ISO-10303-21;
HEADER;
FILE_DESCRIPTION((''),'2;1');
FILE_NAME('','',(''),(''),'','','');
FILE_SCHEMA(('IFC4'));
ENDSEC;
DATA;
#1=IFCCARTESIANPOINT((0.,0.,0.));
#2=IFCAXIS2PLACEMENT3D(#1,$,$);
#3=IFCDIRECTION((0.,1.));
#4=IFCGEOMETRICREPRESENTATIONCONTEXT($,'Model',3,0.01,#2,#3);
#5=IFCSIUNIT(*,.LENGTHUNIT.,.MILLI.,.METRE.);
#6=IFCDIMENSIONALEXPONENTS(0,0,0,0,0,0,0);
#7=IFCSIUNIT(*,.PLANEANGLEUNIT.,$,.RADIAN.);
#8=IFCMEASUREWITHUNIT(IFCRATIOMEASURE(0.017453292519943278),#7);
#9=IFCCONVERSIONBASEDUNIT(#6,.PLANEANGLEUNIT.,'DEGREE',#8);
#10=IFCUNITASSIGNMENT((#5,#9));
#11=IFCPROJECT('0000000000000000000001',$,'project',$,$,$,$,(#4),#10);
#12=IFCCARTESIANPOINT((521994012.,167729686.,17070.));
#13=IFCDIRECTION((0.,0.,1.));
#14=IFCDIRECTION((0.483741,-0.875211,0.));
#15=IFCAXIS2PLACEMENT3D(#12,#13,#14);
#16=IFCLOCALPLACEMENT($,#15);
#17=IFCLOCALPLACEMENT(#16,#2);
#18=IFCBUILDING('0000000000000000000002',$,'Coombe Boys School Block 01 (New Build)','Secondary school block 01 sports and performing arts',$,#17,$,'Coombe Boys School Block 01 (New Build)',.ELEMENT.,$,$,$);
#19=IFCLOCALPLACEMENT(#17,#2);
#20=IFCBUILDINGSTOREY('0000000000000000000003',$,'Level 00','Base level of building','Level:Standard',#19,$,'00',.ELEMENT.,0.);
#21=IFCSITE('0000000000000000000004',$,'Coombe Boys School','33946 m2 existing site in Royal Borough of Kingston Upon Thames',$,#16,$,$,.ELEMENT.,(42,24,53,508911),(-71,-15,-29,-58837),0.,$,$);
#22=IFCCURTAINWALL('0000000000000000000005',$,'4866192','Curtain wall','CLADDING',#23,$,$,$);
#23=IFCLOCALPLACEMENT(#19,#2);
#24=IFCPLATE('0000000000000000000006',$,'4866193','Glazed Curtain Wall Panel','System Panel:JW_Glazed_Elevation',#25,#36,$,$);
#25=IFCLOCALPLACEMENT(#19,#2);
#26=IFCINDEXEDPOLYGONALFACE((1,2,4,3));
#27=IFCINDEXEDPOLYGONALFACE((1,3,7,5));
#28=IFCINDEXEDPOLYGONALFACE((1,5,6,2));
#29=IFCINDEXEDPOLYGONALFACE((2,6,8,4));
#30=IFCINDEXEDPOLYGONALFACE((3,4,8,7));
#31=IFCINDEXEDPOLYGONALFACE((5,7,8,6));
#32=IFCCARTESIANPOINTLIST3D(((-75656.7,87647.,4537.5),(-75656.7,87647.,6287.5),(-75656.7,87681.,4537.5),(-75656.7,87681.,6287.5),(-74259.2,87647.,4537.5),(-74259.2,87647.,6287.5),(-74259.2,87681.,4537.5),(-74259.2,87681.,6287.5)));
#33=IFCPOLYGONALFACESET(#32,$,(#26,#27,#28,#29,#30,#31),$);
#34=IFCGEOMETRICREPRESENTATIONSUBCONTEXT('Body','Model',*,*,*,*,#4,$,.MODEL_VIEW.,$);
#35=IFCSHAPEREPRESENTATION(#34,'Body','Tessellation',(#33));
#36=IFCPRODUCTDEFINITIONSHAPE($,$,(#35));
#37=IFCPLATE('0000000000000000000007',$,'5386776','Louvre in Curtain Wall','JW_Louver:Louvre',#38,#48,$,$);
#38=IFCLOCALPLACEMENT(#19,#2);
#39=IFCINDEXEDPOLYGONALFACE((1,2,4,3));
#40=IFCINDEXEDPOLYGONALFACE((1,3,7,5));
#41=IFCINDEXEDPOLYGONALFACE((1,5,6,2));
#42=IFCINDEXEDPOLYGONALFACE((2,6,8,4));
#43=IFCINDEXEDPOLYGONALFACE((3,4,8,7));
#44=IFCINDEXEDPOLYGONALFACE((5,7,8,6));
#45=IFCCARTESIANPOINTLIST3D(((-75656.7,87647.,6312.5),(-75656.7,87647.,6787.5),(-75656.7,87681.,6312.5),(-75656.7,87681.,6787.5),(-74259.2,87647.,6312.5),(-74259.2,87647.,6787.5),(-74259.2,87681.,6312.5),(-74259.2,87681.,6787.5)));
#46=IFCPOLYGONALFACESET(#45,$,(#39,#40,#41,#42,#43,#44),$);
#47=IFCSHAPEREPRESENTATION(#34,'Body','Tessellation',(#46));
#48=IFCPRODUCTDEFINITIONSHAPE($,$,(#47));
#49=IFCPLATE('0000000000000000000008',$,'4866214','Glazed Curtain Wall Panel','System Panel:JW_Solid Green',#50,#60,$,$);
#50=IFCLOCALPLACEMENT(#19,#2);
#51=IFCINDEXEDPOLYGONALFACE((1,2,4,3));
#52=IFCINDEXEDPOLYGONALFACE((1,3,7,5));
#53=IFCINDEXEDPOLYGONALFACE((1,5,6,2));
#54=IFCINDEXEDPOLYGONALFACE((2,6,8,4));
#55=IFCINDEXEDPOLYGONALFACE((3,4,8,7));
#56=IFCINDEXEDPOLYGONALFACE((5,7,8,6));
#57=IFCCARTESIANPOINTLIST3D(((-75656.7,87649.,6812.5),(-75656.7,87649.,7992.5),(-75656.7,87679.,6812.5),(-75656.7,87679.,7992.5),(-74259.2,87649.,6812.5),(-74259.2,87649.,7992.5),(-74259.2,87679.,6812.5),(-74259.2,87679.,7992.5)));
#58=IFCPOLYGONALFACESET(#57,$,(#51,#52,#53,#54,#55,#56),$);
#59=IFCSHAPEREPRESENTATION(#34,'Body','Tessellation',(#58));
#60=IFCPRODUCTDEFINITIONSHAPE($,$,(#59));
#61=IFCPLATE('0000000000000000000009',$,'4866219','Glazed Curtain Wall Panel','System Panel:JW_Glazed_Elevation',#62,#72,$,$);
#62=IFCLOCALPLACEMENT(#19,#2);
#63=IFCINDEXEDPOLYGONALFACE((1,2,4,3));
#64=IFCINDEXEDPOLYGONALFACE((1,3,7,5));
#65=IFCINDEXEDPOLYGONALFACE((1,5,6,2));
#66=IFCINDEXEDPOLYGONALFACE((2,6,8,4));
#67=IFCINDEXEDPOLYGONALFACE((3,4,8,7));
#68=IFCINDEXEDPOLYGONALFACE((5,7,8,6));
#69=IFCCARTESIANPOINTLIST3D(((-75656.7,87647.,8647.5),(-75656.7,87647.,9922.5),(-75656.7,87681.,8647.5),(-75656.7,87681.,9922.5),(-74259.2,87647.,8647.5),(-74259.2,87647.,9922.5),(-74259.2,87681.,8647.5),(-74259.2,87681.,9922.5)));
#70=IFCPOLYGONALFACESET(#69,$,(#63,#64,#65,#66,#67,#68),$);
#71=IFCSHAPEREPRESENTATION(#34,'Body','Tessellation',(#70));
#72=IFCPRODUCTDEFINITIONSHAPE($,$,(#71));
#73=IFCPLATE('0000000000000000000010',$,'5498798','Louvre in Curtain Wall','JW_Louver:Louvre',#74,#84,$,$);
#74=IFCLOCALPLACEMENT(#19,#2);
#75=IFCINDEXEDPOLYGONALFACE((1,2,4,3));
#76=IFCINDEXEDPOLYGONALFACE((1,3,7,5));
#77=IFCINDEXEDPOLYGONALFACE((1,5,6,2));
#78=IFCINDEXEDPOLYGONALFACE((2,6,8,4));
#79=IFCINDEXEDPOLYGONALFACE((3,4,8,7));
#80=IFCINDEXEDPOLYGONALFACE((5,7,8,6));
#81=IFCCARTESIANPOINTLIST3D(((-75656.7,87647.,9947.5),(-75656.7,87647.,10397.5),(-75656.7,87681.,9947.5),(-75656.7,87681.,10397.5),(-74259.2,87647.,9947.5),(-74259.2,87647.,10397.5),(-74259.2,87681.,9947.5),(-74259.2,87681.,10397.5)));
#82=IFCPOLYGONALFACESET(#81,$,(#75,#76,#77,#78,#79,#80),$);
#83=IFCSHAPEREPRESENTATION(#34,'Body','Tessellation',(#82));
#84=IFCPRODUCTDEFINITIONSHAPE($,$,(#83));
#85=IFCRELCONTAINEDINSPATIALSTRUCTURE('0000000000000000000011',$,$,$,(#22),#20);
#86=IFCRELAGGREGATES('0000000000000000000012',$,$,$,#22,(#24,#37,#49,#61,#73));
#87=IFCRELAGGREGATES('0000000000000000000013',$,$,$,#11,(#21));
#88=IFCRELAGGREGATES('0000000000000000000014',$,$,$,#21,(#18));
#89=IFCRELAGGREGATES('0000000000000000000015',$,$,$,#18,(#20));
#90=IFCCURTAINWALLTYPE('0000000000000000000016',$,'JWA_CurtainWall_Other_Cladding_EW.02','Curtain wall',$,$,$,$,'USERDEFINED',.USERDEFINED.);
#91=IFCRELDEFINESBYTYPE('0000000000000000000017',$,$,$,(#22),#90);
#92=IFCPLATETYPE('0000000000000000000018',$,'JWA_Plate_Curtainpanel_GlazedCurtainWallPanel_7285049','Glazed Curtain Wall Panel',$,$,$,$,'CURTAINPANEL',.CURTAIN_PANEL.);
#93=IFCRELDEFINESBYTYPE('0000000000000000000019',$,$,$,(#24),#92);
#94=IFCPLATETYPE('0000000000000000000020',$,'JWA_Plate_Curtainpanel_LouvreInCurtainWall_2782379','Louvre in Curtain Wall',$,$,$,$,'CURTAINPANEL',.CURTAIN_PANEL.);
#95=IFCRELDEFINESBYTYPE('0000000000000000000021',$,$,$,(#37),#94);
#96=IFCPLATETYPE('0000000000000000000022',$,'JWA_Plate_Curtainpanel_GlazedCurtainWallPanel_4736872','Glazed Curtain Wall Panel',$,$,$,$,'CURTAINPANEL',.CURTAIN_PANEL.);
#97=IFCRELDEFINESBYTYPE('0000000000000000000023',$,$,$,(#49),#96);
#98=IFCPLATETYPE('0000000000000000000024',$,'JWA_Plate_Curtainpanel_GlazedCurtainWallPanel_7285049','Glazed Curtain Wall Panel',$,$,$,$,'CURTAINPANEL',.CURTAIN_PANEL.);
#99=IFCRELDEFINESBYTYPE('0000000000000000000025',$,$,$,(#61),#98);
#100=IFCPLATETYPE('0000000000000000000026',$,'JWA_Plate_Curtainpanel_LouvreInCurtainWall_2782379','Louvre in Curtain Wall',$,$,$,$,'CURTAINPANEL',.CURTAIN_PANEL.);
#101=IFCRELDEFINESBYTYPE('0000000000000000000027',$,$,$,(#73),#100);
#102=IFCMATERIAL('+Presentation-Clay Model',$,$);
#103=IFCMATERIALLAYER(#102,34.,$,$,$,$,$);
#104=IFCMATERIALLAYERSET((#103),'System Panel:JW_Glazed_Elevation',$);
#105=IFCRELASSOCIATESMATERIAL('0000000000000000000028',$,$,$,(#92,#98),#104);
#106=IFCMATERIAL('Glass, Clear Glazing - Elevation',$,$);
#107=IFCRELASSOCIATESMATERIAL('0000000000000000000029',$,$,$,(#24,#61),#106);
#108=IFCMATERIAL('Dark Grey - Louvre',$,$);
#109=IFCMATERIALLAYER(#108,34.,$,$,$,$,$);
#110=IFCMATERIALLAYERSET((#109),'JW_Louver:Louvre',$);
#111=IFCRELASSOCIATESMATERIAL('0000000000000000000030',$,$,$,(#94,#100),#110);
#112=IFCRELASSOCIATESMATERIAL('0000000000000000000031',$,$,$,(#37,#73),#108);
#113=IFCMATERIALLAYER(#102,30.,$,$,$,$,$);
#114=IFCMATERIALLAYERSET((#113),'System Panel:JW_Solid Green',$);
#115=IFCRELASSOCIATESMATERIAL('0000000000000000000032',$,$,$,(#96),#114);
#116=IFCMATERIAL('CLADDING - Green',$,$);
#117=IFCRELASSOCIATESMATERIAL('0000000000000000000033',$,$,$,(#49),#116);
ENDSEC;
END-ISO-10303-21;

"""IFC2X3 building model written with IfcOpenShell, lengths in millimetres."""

from ifc_helpers import new_model, entity, si_unit, converted_unit, direction, frame, origin, origin_2d_with_axis, place, context, subcontext, project, spatial, rectangle, extrude, source, transform, mapped, material, layer, layer_set, type_object, type_shapes, element, aggregate, save


model = new_model("IFC2X3")

# Units and contexts
model_context = context("Model", 3, precision=0.01, world=origin(), true_north=direction((0.0, 1.0)))
body_context = subcontext(model_context, "Body", "Model", "MODEL_VIEW")
ifc_project = project(units=[si_unit("LENGTHUNIT", "METRE", prefix="MILLI"), converted_unit("PLANEANGLEUNIT", "DEGREE", entity("IfcRatioMeasure", 0.017453292519943278), si_unit("PLANEANGLEUNIT", "RADIAN"), dimensions=[0, 0, 0, 0, 0, 0, 0])], contexts=[model_context])

# Site, building, storey
site_placement = place(None, frame((521994012.0, 167729686.0, 17070.0), z_axis=(0.0, 0.0, 1.0), x_axis=(0.483741, -0.875211, 0.0)))
site = spatial("IfcSite", under=ifc_project, at=site_placement, Name="Coombe Boys School", Description="33946 m2 existing site in Royal Borough of Kingston Upon Thames", CompositionType="ELEMENT", RefLatitude=(42, 24, 53, 508911), RefLongitude=(-71, -15, -29, -58837), RefElevation=0.0)
building_placement = place(site_placement, origin())
building = spatial("IfcBuilding", under=site, at=building_placement, Name="Coombe Boys School Block 01 (New Build)", Description="Secondary school block 01 sports and performing arts", LongName="Coombe Boys School Block 01 (New Build)", CompositionType="ELEMENT")
storey_placement = place(building_placement, origin())
storey = spatial("IfcBuildingStorey", under=building, at=storey_placement, Name="Level 00", Description="Base level of building", ObjectType="Level:Standard", LongName="00", CompositionType="ELEMENT", Elevation=0.0)

# Curtain wall
curtain_wall_type = type_object("IfcCurtainWallType", Name="JWA_CurtainWall_Other_Cladding_EW.02", Description="Curtain wall", ElementType="USERDEFINED", PredefinedType="USERDEFINED")
curtain_wall_1_placement = place(storey_placement, origin())
curtain_wall_1 = element("IfcCurtainWall", 1, at=curtain_wall_1_placement, inside=storey, type_object=curtain_wall_type, Name="4866192", Description="Curtain wall", ObjectType="CLADDING")

# Plates
ifc_material_1 = material(Name="Glass, Clear Glazing - Elevation")
ifc_material_2 = material(Name="+Presentation-Clay Model")
ifc_layer_1 = layer(ifc_material_2, 34.0)
ifc_layer_set_1 = layer_set([ifc_layer_1], Name="System Panel:JW_Glazed_Elevation")
plate_type_1 = type_object("IfcPlateType", Name="JWA_Plate_Curtainpanel_GlazedCurtainWallPanel_7285049", Description="Glazed Curtain Wall Panel", ElementType="CURTAINPANEL", PredefinedType="CURTAIN_PANEL", material=ifc_layer_set_1)
shared_shape_1 = source(origin(), body_context, "Body", "SweptSolid", [
    extrude(rectangle(XDim=34.0, YDim=1397.5, at=origin_2d_with_axis()), frame((0.0, 0.0, 0.0), z_axis=(0.0, 0.0, 1.0), x_axis=(0.0, 1.0, 0.0)), (0.0, 0.0, 1.0), 1750.0),
])
type_shapes(plate_type_1, [shared_shape_1])
plate_1_placement = place(curtain_wall_1_placement, frame((-74958.0, 87664.0, 4537.5)))
plate_1 = element("IfcPlate", 2, at=plate_1_placement, type_object=plate_type_1, material=ifc_material_1, Name="4866193", Description="Glazed Curtain Wall Panel", ObjectType="System Panel:JW_Glazed_Elevation", context=body_context, shape_type="MappedRepresentation", body=[
    mapped(shared_shape_1, transform((0.0, 0.0, 0.0), scale=1.0)),
])
ifc_material_3 = material(Name="Dark Grey - Louvre")
ifc_layer_2 = layer(ifc_material_3, 34.0)
ifc_layer_set_2 = layer_set([ifc_layer_2], Name="JW_Louver:Louvre")
plate_type_2 = type_object("IfcPlateType", Name="JWA_Plate_Curtainpanel_LouvreInCurtainWall_2782379", Description="Louvre in Curtain Wall", ElementType="CURTAINPANEL", PredefinedType="CURTAIN_PANEL", material=ifc_layer_set_2)
shared_shape_2 = source(origin(), body_context, "Body", "SweptSolid", [
    extrude(rectangle(XDim=34.0, YDim=1397.5, at=origin_2d_with_axis()), frame((0.0, 0.0, 0.0), z_axis=(0.0, 0.0, 1.0), x_axis=(0.0, 1.0, 0.0)), (0.0, 0.0, 1.0), 475.0),
])
type_shapes(plate_type_2, [shared_shape_2])
plate_2_placement = place(curtain_wall_1_placement, frame((-74958.0, 87664.0, 6312.5)))
plate_2 = element("IfcPlate", 3, at=plate_2_placement, type_object=plate_type_2, material=ifc_material_3, Name="5386776", Description="Louvre in Curtain Wall", ObjectType="JW_Louver:Louvre", context=body_context, shape_type="MappedRepresentation", body=[
    mapped(shared_shape_2, transform((0.0, 0.0, 0.0), scale=1.0)),
])
ifc_material_4 = material(Name="CLADDING - Green")
ifc_layer_3 = layer(ifc_material_2, 30.0)
ifc_layer_set_3 = layer_set([ifc_layer_3], Name="System Panel:JW_Solid Green")
plate_type_3 = type_object("IfcPlateType", Name="JWA_Plate_Curtainpanel_GlazedCurtainWallPanel_4736872", Description="Glazed Curtain Wall Panel", ElementType="CURTAINPANEL", PredefinedType="CURTAIN_PANEL", material=ifc_layer_set_3)
shared_shape_3 = source(origin(), body_context, "Body", "SweptSolid", [
    extrude(rectangle(XDim=30.0, YDim=1397.5, at=origin_2d_with_axis()), frame((0.0, 0.0, 0.0), z_axis=(0.0, 0.0, 1.0), x_axis=(0.0, 1.0, 0.0)), (0.0, 0.0, 1.0), 1180.0),
])
type_shapes(plate_type_3, [shared_shape_3])
plate_3_placement = place(curtain_wall_1_placement, frame((-74958.0, 87664.0, 6812.5)))
plate_3 = element("IfcPlate", 4, at=plate_3_placement, type_object=plate_type_3, material=ifc_material_4, Name="4866214", Description="Glazed Curtain Wall Panel", ObjectType="System Panel:JW_Solid Green", context=body_context, shape_type="MappedRepresentation", body=[
    mapped(shared_shape_3, transform((0.0, 0.0, 0.0), scale=1.0)),
])
plate_type_4 = type_object("IfcPlateType", Name="JWA_Plate_Curtainpanel_GlazedCurtainWallPanel_7285049", Description="Glazed Curtain Wall Panel", ElementType="CURTAINPANEL", PredefinedType="CURTAIN_PANEL", material=ifc_layer_set_1)
shared_shape_4 = source(origin(), body_context, "Body", "SweptSolid", [
    extrude(rectangle(XDim=34.0, YDim=1397.5, at=origin_2d_with_axis()), frame((0.0, 0.0, 0.0), z_axis=(0.0, 0.0, 1.0), x_axis=(0.0, 1.0, 0.0)), (0.0, 0.0, 1.0), 1275.0),
])
type_shapes(plate_type_4, [shared_shape_4])
plate_4_placement = place(curtain_wall_1_placement, frame((-74958.0, 87664.0, 8647.5)))
plate_4 = element("IfcPlate", 5, at=plate_4_placement, type_object=plate_type_4, material=ifc_material_1, Name="4866219", Description="Glazed Curtain Wall Panel", ObjectType="System Panel:JW_Glazed_Elevation", context=body_context, shape_type="MappedRepresentation", body=[
    mapped(shared_shape_4, transform((0.0, 0.0, 0.0), scale=1.0)),
])
plate_type_5 = type_object("IfcPlateType", Name="JWA_Plate_Curtainpanel_LouvreInCurtainWall_2782379", Description="Louvre in Curtain Wall", ElementType="CURTAINPANEL", PredefinedType="CURTAIN_PANEL", material=ifc_layer_set_2)
shared_shape_5 = source(origin(), body_context, "Body", "SweptSolid", [
    extrude(rectangle(XDim=34.0, YDim=1397.5, at=origin_2d_with_axis()), frame((0.0, 0.0, 0.0), z_axis=(0.0, 0.0, 1.0), x_axis=(0.0, 1.0, 0.0)), (0.0, 0.0, 1.0), 450.0),
])
type_shapes(plate_type_5, [shared_shape_5])
plate_5_placement = place(curtain_wall_1_placement, frame((-74958.0, 87664.0, 9947.5)))
plate_5 = element("IfcPlate", 6, at=plate_5_placement, type_object=plate_type_5, material=ifc_material_3, Name="5498798", Description="Louvre in Curtain Wall", ObjectType="JW_Louver:Louvre", context=body_context, shape_type="MappedRepresentation", body=[
    mapped(shared_shape_5, transform((0.0, 0.0, 0.0), scale=1.0)),
])
aggregate(curtain_wall_1, [plate_1, plate_2, plate_3, plate_4, plate_5])

save(model, "model.ifc")
